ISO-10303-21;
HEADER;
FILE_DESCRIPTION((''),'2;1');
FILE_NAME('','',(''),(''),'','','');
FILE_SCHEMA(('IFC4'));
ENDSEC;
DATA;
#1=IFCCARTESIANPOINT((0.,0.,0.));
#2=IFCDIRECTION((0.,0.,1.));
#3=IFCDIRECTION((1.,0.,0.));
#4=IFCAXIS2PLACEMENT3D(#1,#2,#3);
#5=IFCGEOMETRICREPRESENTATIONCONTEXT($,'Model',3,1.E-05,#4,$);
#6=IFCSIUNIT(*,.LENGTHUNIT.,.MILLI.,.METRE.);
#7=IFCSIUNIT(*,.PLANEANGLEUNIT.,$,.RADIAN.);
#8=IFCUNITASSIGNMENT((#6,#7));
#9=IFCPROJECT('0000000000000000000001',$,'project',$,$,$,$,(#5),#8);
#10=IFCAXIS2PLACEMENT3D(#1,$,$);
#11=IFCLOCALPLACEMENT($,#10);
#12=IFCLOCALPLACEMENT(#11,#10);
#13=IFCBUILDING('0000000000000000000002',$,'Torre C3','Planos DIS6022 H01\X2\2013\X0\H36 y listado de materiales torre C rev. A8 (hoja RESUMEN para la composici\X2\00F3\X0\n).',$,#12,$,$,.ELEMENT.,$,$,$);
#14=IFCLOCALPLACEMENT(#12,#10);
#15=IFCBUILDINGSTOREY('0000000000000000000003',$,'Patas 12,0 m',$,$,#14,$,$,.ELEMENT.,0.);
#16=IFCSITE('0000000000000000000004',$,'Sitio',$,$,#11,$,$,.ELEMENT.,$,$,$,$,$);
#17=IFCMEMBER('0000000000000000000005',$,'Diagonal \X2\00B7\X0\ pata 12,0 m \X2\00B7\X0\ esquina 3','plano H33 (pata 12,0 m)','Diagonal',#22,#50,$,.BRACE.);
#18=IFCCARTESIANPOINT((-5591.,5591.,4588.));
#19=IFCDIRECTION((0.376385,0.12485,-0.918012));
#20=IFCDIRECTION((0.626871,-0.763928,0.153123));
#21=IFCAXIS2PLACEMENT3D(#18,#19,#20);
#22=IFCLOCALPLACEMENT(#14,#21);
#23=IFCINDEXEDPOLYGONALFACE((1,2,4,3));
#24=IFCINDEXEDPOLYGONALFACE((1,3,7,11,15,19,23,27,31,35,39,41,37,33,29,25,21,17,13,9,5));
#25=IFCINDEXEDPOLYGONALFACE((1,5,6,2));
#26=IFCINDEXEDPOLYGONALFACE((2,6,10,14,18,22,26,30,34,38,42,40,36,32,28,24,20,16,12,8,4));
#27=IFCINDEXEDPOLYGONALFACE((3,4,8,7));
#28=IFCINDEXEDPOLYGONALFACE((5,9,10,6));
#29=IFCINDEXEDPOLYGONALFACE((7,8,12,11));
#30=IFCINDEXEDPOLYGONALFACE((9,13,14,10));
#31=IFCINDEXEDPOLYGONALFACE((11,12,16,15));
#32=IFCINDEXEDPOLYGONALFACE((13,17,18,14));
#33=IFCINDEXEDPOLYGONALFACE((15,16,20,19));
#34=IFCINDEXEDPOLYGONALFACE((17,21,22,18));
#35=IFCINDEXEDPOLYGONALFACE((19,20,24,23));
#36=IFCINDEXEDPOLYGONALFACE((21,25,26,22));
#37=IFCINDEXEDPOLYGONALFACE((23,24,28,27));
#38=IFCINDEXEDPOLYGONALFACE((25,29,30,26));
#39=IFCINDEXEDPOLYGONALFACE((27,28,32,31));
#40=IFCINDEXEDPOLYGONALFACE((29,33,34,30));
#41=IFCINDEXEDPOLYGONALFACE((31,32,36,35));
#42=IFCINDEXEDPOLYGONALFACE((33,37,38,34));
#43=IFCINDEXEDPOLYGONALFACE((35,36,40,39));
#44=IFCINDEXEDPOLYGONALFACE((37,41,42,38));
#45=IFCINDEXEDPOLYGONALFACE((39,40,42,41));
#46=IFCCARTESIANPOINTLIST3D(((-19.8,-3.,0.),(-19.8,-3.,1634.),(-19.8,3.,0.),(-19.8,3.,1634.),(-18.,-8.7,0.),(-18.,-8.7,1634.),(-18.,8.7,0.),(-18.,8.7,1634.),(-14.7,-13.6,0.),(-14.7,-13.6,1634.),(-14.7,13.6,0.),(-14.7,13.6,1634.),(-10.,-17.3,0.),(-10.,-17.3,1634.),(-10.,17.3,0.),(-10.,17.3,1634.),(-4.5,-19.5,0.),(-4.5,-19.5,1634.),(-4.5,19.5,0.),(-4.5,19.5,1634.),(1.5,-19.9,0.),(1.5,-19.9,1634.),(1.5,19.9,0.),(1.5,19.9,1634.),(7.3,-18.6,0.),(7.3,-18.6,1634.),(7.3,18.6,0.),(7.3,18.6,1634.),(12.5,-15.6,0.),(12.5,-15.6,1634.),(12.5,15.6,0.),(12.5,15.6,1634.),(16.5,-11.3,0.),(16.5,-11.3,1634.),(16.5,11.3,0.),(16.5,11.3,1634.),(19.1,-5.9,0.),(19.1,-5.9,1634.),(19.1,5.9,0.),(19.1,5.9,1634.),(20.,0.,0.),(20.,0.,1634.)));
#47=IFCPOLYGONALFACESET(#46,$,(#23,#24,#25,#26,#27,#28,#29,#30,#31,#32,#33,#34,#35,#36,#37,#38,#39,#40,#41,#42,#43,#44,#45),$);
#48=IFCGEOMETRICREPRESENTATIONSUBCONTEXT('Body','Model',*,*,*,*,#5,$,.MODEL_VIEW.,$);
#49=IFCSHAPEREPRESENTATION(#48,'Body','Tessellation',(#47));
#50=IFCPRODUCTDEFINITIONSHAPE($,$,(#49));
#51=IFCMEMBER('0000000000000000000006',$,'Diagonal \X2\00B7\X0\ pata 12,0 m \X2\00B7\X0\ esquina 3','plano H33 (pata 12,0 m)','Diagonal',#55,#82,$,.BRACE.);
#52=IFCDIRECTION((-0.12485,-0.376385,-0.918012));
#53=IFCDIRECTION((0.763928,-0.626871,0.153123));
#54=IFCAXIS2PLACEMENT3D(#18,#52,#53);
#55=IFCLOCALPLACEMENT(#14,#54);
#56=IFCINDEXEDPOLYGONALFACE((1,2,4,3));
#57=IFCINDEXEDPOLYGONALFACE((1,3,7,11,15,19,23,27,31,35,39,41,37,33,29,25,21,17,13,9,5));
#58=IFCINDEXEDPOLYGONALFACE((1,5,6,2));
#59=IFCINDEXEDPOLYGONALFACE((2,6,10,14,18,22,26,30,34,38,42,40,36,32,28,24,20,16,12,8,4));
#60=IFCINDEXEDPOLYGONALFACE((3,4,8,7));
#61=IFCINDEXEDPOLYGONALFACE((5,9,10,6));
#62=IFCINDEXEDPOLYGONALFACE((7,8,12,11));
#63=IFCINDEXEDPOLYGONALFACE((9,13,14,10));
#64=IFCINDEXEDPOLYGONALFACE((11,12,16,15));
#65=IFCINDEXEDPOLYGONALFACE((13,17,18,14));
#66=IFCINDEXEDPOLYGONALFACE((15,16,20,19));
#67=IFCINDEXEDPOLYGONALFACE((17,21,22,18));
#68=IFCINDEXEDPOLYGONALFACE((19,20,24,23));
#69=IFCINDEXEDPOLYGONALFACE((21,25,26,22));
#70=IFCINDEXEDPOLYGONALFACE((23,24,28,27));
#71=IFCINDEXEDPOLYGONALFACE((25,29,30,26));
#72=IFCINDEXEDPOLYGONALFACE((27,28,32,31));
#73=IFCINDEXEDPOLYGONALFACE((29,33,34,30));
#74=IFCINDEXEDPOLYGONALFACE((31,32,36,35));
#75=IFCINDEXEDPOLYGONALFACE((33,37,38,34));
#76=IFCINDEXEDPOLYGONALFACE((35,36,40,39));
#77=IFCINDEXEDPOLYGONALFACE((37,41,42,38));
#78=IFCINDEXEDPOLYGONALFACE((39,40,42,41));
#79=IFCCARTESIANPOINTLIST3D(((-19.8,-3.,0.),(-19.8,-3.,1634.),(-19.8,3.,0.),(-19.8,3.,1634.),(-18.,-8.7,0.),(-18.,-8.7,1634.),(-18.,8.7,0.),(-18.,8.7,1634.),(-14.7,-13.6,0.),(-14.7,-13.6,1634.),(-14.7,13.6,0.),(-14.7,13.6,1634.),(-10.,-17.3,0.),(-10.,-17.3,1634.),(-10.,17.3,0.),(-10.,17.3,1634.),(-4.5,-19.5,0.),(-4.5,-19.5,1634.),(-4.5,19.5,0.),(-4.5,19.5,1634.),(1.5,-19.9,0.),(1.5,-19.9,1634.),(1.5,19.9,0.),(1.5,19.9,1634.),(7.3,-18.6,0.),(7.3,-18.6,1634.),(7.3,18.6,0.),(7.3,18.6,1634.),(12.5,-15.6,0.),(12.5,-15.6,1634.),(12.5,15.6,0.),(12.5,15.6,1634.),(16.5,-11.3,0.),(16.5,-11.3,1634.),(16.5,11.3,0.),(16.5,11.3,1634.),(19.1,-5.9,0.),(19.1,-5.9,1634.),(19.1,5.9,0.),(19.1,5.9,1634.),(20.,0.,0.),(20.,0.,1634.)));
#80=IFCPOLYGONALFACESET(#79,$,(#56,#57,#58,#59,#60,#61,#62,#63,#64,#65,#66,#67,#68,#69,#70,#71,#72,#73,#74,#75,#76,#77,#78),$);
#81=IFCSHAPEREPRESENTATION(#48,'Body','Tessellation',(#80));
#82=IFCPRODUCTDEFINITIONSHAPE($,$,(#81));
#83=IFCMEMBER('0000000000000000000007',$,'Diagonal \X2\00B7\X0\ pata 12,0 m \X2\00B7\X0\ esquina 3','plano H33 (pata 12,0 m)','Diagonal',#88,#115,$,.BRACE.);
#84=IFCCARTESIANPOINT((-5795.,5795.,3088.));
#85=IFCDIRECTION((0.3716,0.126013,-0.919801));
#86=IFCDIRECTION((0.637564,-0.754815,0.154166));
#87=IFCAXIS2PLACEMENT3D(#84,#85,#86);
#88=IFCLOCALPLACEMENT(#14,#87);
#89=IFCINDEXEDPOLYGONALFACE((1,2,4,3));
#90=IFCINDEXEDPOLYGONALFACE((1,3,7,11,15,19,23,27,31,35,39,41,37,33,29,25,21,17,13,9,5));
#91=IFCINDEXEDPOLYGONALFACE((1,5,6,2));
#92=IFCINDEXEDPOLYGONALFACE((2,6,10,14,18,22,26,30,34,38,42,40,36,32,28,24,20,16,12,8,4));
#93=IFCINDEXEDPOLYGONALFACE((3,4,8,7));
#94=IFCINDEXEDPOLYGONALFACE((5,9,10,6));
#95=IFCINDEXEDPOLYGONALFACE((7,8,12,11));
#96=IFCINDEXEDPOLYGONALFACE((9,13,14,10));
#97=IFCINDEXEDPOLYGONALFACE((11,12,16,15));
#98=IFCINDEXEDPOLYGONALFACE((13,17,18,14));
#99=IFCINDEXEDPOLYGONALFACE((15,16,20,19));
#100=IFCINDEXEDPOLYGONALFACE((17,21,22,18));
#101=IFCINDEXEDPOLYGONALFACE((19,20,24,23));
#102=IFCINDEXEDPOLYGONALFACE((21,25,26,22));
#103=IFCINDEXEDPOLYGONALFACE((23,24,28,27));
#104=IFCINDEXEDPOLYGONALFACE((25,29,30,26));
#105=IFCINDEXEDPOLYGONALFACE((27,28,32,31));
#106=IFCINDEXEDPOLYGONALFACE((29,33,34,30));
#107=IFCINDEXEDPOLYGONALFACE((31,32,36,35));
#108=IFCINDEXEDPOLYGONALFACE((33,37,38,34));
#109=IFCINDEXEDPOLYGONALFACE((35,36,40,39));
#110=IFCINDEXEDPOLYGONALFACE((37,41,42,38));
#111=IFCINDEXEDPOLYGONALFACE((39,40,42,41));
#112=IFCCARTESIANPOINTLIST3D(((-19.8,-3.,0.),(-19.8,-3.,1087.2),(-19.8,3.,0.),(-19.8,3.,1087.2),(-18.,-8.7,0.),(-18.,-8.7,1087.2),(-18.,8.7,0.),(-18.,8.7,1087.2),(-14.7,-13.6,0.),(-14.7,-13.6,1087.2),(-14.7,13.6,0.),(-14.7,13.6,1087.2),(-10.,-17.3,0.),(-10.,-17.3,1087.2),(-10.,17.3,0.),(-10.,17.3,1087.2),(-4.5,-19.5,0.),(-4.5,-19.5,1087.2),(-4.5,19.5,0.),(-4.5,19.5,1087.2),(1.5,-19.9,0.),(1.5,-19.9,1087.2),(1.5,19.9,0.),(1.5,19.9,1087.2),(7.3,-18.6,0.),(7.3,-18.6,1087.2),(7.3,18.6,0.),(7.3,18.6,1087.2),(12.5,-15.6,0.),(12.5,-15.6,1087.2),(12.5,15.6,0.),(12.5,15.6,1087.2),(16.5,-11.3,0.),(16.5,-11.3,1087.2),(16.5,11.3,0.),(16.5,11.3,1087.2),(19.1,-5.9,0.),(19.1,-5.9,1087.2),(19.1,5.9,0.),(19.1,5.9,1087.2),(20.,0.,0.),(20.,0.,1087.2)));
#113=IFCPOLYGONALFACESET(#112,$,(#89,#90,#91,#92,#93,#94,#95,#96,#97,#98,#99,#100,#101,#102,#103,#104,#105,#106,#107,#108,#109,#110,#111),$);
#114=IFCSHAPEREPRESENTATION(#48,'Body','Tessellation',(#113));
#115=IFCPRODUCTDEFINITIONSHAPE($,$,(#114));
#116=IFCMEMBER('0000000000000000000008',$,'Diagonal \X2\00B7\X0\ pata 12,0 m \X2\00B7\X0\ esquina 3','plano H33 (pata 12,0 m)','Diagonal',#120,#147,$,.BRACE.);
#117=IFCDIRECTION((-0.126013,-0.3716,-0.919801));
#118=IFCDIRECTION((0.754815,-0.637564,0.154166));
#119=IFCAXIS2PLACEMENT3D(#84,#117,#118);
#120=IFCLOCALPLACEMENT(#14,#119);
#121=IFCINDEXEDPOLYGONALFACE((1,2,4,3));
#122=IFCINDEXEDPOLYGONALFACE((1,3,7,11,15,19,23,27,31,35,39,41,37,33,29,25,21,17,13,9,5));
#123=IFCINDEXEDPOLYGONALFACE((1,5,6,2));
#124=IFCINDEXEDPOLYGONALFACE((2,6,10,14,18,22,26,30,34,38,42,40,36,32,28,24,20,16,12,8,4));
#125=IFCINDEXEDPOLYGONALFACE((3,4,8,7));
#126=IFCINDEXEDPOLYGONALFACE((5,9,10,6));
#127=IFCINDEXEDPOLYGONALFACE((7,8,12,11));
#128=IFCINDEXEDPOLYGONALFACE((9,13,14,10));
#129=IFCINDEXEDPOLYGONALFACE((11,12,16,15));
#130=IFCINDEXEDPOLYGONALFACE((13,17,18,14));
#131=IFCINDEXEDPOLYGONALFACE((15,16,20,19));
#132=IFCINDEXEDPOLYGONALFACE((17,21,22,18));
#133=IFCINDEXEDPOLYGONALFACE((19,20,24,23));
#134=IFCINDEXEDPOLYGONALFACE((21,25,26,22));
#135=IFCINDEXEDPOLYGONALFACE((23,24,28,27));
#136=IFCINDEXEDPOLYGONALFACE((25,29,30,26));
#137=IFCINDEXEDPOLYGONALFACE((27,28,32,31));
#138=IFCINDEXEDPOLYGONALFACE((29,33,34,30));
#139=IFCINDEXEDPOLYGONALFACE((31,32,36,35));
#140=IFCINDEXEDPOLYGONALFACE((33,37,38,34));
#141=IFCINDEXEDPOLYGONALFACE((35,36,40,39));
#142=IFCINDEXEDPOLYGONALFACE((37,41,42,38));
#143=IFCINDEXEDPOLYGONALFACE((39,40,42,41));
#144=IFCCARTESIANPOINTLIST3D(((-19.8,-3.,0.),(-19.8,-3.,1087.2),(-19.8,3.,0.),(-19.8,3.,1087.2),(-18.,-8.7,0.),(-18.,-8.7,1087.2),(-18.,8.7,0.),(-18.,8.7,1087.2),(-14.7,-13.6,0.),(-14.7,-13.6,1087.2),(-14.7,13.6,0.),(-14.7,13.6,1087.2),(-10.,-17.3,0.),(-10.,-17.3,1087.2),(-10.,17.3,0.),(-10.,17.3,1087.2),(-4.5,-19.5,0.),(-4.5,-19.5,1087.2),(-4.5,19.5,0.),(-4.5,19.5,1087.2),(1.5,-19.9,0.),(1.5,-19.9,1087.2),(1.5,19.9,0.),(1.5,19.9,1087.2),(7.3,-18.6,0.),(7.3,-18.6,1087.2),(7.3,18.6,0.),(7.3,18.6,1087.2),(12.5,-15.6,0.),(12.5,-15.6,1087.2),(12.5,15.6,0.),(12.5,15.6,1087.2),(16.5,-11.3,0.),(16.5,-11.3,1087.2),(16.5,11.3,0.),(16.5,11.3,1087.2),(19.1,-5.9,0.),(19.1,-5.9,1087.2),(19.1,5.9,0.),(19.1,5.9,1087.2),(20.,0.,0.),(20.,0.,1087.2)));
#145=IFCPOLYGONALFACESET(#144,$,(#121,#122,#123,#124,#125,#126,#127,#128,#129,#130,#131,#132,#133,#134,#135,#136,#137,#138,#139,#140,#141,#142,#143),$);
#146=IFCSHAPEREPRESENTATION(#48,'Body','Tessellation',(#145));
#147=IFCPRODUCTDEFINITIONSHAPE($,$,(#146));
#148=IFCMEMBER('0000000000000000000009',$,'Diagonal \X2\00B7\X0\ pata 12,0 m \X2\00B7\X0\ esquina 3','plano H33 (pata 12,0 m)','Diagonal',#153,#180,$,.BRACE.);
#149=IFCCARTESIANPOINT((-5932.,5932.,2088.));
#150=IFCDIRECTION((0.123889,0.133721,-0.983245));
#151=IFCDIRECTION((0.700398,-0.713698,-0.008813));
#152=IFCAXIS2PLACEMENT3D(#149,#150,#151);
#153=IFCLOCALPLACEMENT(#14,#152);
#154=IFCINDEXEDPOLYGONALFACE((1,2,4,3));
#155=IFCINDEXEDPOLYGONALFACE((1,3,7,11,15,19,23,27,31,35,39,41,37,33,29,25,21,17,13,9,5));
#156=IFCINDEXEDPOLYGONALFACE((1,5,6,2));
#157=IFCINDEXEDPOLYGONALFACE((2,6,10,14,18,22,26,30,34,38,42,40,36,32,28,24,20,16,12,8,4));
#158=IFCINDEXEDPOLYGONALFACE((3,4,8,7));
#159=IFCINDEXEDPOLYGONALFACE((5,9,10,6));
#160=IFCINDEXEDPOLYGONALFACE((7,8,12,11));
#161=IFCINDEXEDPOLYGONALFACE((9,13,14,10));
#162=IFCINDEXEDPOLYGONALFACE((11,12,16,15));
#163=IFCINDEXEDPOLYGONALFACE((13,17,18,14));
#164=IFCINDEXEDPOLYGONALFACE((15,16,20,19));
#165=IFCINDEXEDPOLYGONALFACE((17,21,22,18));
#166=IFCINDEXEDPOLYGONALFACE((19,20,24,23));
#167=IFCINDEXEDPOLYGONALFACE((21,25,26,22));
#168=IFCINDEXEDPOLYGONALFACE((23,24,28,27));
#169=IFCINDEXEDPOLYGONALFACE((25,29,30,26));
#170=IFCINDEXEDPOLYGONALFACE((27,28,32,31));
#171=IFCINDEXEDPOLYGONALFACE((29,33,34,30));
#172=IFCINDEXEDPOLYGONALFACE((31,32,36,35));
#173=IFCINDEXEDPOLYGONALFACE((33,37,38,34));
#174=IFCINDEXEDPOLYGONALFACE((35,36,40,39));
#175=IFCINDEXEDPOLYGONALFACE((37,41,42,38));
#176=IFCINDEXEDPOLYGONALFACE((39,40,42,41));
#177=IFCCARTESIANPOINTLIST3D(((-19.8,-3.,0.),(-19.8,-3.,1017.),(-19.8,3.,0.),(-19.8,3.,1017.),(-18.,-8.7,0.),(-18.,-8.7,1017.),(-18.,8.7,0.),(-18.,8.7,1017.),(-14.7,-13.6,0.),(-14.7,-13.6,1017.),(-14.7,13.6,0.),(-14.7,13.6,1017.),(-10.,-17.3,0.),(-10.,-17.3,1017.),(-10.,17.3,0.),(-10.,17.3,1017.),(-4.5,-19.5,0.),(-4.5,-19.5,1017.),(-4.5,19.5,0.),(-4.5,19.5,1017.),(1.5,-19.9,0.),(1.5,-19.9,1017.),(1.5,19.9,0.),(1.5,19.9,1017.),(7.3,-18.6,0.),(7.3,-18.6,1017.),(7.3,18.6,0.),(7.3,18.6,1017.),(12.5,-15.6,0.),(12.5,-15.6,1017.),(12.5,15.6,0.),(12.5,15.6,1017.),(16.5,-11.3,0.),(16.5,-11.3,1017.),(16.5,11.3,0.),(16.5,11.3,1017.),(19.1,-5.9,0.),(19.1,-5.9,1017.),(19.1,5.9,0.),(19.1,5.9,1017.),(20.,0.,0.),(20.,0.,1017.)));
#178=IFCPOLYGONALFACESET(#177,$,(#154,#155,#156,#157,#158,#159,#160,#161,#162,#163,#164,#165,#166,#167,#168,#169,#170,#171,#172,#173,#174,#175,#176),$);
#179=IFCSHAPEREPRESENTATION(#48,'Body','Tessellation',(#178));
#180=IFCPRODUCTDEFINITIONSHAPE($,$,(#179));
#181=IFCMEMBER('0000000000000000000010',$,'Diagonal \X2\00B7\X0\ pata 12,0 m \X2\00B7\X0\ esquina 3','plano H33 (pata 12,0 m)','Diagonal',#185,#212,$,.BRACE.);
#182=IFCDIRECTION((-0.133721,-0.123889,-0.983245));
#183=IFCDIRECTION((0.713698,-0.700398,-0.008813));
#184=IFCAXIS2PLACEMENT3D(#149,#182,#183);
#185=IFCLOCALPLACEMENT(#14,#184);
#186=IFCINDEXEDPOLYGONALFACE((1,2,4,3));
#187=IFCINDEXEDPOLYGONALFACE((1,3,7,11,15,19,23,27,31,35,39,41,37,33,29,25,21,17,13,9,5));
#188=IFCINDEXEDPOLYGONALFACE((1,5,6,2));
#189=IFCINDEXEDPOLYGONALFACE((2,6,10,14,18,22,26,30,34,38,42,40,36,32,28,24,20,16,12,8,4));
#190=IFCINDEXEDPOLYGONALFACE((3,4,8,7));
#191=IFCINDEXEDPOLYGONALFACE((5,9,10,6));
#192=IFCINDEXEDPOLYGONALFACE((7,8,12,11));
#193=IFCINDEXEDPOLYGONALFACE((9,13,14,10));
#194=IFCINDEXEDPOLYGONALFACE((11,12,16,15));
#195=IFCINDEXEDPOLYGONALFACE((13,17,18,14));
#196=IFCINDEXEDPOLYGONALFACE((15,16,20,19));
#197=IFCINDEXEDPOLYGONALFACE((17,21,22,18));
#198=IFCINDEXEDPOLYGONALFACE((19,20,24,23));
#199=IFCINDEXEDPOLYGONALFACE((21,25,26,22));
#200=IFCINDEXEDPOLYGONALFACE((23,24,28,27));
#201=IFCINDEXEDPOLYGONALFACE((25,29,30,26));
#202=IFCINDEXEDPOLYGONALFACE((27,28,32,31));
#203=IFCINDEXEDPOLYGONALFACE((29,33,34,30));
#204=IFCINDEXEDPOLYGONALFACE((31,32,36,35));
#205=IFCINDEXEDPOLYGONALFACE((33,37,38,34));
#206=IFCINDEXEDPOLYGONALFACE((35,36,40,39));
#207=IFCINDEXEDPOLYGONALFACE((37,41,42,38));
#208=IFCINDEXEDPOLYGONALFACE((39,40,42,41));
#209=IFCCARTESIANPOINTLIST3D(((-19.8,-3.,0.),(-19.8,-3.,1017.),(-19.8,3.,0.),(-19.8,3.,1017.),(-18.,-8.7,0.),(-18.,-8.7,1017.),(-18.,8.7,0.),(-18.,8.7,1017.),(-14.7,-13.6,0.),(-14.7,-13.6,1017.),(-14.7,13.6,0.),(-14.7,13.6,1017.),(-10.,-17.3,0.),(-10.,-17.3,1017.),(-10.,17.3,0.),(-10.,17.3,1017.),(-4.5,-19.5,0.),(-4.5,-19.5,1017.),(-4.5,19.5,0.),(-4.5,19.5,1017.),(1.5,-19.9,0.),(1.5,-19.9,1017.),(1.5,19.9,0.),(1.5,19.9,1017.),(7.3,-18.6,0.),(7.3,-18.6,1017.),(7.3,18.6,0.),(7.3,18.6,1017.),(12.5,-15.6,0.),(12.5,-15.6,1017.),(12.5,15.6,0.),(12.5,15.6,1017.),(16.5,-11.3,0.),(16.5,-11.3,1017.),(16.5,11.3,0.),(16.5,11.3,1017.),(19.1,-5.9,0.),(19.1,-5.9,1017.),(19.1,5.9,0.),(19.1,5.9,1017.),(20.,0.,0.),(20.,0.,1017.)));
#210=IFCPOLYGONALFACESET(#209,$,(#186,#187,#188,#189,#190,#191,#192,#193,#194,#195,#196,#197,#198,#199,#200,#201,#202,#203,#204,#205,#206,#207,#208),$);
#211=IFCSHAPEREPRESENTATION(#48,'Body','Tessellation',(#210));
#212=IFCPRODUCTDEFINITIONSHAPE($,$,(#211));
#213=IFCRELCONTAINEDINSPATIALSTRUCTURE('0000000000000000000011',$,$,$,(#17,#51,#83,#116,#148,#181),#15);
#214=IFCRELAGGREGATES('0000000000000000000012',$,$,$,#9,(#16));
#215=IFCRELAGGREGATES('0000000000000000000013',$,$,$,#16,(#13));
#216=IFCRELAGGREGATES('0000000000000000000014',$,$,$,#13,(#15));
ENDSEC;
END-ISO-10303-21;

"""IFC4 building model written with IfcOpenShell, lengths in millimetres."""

from ifc_helpers import new_model, si_unit, frame, origin, origin_with_axes, place, context, subcontext, project, spatial, circle, extrude, element, save


model = new_model("IFC4")

# Units and contexts
model_context = context("Model", 3, precision=1e-05, world=origin_with_axes())
body_context = subcontext(model_context, "Body", "Model", "MODEL_VIEW")
ifc_project = project(units=[si_unit("LENGTHUNIT", "METRE", prefix="MILLI"), si_unit("PLANEANGLEUNIT", "RADIAN")], contexts=[model_context])

# Site, building, storey
site_placement = place(None, origin())
site = spatial("IfcSite", under=ifc_project, at=site_placement, Name="Sitio", CompositionType="ELEMENT")
building_placement = place(site_placement, origin())
building = spatial("IfcBuilding", under=site, at=building_placement, Name="Torre C3", Description="Planos DIS6022 H01–H36 y listado de materiales torre C rev. A8 (hoja RESUMEN para la composición).", CompositionType="ELEMENT")
storey_placement = place(building_placement, origin())
storey = spatial("IfcBuildingStorey", under=building, at=storey_placement, Name="Patas 12,0 m", CompositionType="ELEMENT", Elevation=0.0)

# Members
for number, where, z_axis, x_axis, name in (
    (1, (-5591.0, 5591.0, 4588.0), (0.376385, 0.12485, -0.918012), (0.626871, -0.763928, 0.153123), "Diagonal · pata 12,0 m · esquina 3"),
    (2, (-5591.0, 5591.0, 4588.0), (-0.12485, -0.376385, -0.918012), (0.763928, -0.626871, 0.153123), "Diagonal · pata 12,0 m · esquina 3"),
):
    element("IfcMember", number, at=place(storey_placement, frame(where, z_axis=z_axis, x_axis=x_axis)), inside=storey, Name=name, Description="plano H33 (pata 12,0 m)", ObjectType="Diagonal", PredefinedType="BRACE", context=body_context, shape_type="SweptSolid", body=[
        extrude(circle(Radius=20.0), None, (0.0, 0.0, 1.0), 1634.0),
    ])
for number, where, z_axis, x_axis, name in (
    (3, (-5795.0, 5795.0, 3088.0), (0.3716, 0.126013, -0.919801), (0.637564, -0.754815, 0.154166), "Diagonal · pata 12,0 m · esquina 3"),
    (4, (-5795.0, 5795.0, 3088.0), (-0.126013, -0.3716, -0.919801), (0.754815, -0.637564, 0.154166), "Diagonal · pata 12,0 m · esquina 3"),
):
    element("IfcMember", number, at=place(storey_placement, frame(where, z_axis=z_axis, x_axis=x_axis)), inside=storey, Name=name, Description="plano H33 (pata 12,0 m)", ObjectType="Diagonal", PredefinedType="BRACE", context=body_context, shape_type="SweptSolid", body=[
        extrude(circle(Radius=20.0), None, (0.0, 0.0, 1.0), 1087.2),
    ])
for number, where, z_axis, x_axis, name in (
    (5, (-5932.0, 5932.0, 2088.0), (0.123889, 0.133721, -0.983245), (0.700398, -0.713698, -0.008813), "Diagonal · pata 12,0 m · esquina 3"),
    (6, (-5932.0, 5932.0, 2088.0), (-0.133721, -0.123889, -0.983245), (0.713698, -0.700398, -0.008813), "Diagonal · pata 12,0 m · esquina 3"),
):
    element("IfcMember", number, at=place(storey_placement, frame(where, z_axis=z_axis, x_axis=x_axis)), inside=storey, Name=name, Description="plano H33 (pata 12,0 m)", ObjectType="Diagonal", PredefinedType="BRACE", context=body_context, shape_type="SweptSolid", body=[
        extrude(circle(Radius=20.0), None, (0.0, 0.0, 1.0), 1017.0),
    ])

save(model, "model.ifc")
